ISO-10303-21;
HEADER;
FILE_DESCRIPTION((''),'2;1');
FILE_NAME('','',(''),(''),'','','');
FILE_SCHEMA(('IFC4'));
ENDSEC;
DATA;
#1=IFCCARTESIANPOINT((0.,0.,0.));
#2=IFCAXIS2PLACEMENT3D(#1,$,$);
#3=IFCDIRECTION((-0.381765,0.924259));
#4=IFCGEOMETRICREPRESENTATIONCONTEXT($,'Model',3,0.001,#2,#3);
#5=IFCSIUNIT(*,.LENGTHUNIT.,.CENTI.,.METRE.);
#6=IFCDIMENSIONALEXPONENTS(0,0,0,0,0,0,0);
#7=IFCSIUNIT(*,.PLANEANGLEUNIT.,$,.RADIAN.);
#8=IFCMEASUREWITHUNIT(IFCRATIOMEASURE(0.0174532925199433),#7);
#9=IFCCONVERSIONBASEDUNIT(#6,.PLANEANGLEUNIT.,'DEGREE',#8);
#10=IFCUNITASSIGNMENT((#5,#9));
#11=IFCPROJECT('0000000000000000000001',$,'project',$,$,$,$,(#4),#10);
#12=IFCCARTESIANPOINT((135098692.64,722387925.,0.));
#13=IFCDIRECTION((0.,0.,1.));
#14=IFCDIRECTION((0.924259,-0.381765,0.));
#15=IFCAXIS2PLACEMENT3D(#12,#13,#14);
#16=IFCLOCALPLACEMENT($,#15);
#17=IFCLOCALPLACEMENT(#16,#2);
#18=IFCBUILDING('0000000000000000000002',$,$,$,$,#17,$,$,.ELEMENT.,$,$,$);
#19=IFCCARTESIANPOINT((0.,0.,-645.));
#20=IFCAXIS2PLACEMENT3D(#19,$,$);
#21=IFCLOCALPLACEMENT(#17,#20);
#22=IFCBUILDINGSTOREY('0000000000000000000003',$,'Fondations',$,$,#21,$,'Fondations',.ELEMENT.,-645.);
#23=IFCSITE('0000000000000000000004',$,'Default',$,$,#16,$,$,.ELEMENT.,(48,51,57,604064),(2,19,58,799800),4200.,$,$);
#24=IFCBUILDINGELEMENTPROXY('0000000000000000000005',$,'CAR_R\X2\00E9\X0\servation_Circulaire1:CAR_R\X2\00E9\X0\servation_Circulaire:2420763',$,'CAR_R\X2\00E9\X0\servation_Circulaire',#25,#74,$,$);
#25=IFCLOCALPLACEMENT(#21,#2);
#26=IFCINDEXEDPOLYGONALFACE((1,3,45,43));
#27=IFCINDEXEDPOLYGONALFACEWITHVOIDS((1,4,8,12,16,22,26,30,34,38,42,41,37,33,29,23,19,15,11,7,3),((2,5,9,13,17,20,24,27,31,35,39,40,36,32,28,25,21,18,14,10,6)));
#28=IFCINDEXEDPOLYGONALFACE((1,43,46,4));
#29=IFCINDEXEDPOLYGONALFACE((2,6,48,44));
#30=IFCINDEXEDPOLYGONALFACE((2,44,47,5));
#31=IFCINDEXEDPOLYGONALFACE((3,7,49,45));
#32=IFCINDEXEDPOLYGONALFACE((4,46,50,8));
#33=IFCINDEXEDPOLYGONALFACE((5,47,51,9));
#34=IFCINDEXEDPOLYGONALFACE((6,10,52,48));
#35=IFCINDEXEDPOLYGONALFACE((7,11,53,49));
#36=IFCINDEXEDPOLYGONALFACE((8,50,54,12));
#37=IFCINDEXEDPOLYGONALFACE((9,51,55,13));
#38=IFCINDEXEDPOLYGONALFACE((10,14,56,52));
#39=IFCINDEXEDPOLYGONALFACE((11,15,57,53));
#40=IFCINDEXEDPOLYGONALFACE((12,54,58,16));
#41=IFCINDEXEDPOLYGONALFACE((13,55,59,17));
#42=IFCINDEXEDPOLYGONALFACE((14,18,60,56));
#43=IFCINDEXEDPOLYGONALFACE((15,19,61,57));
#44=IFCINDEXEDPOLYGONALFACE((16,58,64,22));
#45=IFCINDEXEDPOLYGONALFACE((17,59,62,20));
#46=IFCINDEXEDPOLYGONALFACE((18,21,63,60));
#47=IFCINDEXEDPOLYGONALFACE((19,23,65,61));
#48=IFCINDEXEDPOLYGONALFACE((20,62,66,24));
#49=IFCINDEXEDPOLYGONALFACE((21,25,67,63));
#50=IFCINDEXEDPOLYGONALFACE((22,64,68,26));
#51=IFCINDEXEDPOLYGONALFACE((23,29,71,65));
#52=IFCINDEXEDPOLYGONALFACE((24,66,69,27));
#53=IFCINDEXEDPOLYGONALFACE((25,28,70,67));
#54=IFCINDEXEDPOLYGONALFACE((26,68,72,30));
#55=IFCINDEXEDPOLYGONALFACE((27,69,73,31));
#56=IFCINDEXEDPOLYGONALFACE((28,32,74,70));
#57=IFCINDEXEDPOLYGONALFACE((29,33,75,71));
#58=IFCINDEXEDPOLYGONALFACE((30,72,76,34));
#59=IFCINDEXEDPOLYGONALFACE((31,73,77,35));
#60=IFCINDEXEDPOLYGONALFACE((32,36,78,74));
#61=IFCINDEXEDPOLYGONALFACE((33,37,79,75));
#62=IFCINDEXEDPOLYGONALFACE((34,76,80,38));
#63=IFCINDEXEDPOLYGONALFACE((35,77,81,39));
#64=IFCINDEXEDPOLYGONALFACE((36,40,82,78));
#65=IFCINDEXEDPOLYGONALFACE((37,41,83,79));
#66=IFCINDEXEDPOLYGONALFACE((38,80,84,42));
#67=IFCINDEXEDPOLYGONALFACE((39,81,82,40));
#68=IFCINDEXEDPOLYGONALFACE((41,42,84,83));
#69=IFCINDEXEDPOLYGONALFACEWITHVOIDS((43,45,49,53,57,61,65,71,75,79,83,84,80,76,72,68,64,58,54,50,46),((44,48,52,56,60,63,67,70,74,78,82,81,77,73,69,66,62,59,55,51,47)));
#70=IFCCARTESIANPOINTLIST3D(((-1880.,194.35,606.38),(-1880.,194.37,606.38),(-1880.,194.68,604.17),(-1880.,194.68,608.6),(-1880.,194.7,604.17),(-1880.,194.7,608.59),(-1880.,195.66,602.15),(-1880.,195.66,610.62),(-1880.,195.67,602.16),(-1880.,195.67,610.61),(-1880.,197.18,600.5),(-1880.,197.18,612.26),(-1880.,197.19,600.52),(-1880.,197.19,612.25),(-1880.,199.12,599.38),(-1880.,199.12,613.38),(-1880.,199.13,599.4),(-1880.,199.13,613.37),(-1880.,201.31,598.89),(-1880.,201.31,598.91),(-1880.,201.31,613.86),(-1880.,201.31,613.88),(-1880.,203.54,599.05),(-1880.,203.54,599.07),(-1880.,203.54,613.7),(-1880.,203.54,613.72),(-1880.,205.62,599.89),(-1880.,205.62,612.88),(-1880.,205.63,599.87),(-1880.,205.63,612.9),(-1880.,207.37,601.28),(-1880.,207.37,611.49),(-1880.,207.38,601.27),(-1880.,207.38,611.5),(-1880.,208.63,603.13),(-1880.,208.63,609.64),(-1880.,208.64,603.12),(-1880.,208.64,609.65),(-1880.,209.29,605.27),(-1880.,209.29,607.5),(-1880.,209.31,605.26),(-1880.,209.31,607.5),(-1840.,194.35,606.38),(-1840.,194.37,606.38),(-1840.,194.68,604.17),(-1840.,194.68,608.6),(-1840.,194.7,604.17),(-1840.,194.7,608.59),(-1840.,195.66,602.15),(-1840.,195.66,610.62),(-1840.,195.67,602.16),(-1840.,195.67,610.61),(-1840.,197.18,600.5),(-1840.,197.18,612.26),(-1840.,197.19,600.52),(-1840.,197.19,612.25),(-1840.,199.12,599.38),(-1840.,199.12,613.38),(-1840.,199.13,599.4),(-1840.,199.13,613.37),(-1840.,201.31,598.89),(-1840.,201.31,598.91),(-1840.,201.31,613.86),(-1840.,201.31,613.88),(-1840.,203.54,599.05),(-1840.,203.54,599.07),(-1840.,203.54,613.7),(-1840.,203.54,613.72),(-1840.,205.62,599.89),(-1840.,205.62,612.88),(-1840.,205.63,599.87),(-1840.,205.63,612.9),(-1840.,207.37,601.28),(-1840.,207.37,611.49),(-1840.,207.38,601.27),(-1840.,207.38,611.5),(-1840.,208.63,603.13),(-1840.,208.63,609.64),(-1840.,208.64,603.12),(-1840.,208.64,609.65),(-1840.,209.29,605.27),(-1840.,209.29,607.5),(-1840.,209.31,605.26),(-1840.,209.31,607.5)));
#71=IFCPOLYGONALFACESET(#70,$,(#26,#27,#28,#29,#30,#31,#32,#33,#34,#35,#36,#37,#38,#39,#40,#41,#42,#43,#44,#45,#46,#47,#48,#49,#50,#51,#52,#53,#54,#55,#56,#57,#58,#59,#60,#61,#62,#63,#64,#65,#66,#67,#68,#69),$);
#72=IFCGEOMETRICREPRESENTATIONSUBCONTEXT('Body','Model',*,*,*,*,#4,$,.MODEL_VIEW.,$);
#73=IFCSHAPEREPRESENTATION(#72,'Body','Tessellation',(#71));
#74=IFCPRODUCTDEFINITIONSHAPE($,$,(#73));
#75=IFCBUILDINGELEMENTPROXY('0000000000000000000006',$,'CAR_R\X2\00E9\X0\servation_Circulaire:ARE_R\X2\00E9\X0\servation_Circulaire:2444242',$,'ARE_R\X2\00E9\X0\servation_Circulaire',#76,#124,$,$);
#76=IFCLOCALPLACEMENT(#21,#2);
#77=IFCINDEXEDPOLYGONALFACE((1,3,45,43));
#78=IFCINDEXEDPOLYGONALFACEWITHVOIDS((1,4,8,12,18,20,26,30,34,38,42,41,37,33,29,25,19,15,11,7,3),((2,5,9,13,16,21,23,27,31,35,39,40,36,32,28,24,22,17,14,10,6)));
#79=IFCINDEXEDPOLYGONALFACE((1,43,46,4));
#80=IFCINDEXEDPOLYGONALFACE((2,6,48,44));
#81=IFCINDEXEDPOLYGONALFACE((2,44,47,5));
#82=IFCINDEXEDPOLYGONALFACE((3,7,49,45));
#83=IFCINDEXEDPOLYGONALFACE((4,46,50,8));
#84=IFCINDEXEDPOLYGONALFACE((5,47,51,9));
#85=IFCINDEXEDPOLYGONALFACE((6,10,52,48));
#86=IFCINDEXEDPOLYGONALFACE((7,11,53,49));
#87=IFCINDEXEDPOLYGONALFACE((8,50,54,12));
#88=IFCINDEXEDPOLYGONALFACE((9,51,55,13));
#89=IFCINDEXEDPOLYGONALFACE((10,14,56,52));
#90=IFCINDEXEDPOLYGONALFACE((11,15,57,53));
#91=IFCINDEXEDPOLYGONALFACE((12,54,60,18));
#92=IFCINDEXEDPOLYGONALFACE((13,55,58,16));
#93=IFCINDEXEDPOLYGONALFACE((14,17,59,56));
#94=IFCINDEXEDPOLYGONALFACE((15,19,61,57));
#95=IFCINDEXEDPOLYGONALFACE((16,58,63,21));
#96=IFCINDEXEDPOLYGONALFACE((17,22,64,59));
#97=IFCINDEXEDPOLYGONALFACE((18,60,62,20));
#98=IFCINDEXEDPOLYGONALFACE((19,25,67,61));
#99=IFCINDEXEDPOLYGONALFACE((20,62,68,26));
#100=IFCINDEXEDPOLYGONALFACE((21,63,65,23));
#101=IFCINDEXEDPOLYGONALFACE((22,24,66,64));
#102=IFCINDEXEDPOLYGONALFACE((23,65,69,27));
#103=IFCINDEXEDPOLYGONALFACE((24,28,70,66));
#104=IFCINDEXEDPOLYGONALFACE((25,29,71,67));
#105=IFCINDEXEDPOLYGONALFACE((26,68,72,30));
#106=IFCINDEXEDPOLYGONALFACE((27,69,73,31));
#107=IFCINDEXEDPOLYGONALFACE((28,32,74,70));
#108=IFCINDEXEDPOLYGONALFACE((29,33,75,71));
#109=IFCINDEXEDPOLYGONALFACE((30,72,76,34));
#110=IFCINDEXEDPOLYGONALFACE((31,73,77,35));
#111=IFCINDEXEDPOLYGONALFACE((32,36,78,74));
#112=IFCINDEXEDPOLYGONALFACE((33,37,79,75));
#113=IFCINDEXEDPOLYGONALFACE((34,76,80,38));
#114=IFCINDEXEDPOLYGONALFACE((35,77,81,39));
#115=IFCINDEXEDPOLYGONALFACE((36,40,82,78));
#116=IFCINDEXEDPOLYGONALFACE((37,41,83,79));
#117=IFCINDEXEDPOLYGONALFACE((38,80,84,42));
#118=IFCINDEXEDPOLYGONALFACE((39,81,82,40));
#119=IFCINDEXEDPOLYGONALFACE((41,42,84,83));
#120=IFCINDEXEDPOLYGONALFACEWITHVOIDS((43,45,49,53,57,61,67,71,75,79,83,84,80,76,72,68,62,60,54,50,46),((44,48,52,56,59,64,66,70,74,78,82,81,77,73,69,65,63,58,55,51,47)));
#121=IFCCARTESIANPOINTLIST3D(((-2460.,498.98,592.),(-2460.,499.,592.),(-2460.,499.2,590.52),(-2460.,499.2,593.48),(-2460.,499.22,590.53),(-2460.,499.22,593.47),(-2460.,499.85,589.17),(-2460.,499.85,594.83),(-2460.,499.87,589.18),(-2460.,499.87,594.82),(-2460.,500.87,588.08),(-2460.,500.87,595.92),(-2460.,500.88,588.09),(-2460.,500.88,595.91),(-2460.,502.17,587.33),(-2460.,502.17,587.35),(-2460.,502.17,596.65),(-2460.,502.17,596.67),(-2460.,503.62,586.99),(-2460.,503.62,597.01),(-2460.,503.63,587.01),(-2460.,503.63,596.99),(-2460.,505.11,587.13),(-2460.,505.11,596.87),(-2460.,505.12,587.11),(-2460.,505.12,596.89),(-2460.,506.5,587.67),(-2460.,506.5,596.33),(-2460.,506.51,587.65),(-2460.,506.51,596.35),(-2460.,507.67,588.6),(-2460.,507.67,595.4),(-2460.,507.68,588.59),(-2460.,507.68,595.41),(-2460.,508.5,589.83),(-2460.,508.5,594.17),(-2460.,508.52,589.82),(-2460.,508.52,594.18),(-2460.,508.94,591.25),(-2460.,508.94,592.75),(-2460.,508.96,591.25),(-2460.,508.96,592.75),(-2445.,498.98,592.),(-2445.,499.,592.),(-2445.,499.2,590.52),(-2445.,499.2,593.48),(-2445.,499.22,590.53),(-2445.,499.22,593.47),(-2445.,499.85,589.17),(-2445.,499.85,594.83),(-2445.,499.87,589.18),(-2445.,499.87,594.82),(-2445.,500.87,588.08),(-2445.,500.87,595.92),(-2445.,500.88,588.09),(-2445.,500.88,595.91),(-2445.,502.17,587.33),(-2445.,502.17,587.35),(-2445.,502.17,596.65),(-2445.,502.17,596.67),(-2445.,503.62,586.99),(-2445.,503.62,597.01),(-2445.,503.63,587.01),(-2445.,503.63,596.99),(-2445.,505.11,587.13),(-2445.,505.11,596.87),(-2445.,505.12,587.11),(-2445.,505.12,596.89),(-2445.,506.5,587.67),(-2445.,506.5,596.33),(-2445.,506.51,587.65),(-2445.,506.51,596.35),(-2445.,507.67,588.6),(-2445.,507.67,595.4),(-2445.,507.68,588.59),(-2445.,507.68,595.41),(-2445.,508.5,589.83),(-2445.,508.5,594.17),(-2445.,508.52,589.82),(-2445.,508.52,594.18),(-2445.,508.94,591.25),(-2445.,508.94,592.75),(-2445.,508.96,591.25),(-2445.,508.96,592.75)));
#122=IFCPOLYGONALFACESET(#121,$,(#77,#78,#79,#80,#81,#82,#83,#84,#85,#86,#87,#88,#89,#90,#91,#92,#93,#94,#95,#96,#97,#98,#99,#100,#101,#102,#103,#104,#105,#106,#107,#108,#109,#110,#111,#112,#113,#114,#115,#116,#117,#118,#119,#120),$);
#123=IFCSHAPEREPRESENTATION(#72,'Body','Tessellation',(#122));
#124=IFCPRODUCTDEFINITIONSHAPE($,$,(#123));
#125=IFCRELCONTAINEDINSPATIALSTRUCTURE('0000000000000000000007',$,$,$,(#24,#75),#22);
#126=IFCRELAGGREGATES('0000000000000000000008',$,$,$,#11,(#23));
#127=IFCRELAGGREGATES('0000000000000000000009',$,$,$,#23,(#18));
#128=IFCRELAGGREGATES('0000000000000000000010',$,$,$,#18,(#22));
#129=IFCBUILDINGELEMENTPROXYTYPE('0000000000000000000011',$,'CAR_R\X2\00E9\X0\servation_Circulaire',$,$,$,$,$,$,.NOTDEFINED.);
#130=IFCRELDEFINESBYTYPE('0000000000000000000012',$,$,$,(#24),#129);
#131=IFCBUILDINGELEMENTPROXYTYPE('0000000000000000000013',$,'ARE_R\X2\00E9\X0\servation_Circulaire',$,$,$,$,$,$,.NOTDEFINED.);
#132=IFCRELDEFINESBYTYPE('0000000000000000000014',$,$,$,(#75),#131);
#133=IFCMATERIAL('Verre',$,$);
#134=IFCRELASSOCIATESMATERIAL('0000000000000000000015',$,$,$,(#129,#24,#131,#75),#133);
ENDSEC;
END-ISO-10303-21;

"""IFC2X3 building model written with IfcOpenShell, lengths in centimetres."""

from ifc_helpers import new_model, entity, si_unit, converted_unit, direction, frame, frame_2d, origin, place, context, subcontext, project, spatial, hollow_circle, extrude, source, transform, mapped, material, type_object, type_shapes, element, save


model = new_model("IFC2X3")

# Units and contexts
model_context = context("Model", 3, precision=0.001, world=origin(), true_north=direction((-0.381765, 0.924259)))
body_context = subcontext(model_context, "Body", "Model", "MODEL_VIEW")
ifc_project = project(units=[si_unit("LENGTHUNIT", "METRE", prefix="CENTI"), converted_unit("PLANEANGLEUNIT", "DEGREE", entity("IfcRatioMeasure", 0.0174532925199433), si_unit("PLANEANGLEUNIT", "RADIAN"), dimensions=[0, 0, 0, 0, 0, 0, 0])], contexts=[model_context])

# Site, building, storey
site_placement = place(None, frame((135098692.64, 722387925.0, 0.0), z_axis=(0.0, 0.0, 1.0), x_axis=(0.924259, -0.381765, 0.0)))
site = spatial("IfcSite", under=ifc_project, at=site_placement, Name="Default", CompositionType="ELEMENT", RefLatitude=(48, 51, 57, 604064), RefLongitude=(2, 19, 58, 799800), RefElevation=4200.0)
building_placement = place(site_placement, origin())
building = spatial("IfcBuilding", under=site, at=building_placement, CompositionType="ELEMENT")
storey_placement = place(building_placement, frame((0.0, 0.0, -645.0)))
storey = spatial("IfcBuildingStorey", under=building, at=storey_placement, Name="Fondations", LongName="Fondations", CompositionType="ELEMENT", Elevation=-645.0)

# Building element proxies
ifc_material_1 = material(Name="Verre")
building_element_proxy_type_1 = type_object("IfcBuildingElementProxyType", Name="CAR_Réservation_Circulaire", PredefinedType="NOTDEFINED", material=ifc_material_1)
shared_shape_1 = source(origin(), body_context, "Body", "SweptSolid", [
    extrude(hollow_circle(Radius=7.52, WallThickness=0.02, at=frame_2d((0.0, 0.0), x_axis=(1.0, 0.0))), frame((0.0, 0.0, -40.0)), (0.0, 0.0, 1.0), 40.0),
])
type_shapes(building_element_proxy_type_1, [shared_shape_1])
for number, where, z_axis, x_axis, name in (
    (1, (-1880.0, 201.87, 606.38), (-1.0, 0.0, 0.0), (0.0, -1.0, 0.0), "CAR_Réservation_Circulaire1:CAR_Réservation_Circulaire:2420763"),
):
    element("IfcBuildingElementProxy", number, at=place(storey_placement, frame(where, z_axis=z_axis, x_axis=x_axis)), inside=storey, type_object=building_element_proxy_type_1, material=ifc_material_1, Name=name, ObjectType="CAR_Réservation_Circulaire", context=body_context, shape_type="MappedRepresentation", body=[
        mapped(shared_shape_1, transform((0.0, 0.0, 0.0), scale=1.0)),
    ])
building_element_proxy_type_2 = type_object("IfcBuildingElementProxyType", Name="ARE_Réservation_Circulaire", PredefinedType="NOTDEFINED", material=ifc_material_1)
shared_shape_2 = source(origin(), body_context, "Body", "SweptSolid", [
    extrude(hollow_circle(Radius=5.02, WallThickness=0.02, at=frame_2d((0.0, 0.0), x_axis=(1.0, 0.0))), frame((0.0, 0.0, -15.0)), (0.0, 0.0, 1.0), 15.0),
])
type_shapes(building_element_proxy_type_2, [shared_shape_2])
proxy_1_placement = place(storey_placement, frame((-2460.0, 504.0, 592.0), z_axis=(-1.0, 0.0, 0.0), x_axis=(0.0, -1.0, 0.0)))
element("IfcBuildingElementProxy", 2, at=proxy_1_placement, inside=storey, type_object=building_element_proxy_type_2, material=ifc_material_1, Name="CAR_Réservation_Circulaire:ARE_Réservation_Circulaire:2444242", ObjectType="ARE_Réservation_Circulaire", context=body_context, shape_type="MappedRepresentation", body=[
    mapped(shared_shape_2, transform((0.0, 0.0, 0.0), scale=1.0)),
])

save(model, "model.ifc")
